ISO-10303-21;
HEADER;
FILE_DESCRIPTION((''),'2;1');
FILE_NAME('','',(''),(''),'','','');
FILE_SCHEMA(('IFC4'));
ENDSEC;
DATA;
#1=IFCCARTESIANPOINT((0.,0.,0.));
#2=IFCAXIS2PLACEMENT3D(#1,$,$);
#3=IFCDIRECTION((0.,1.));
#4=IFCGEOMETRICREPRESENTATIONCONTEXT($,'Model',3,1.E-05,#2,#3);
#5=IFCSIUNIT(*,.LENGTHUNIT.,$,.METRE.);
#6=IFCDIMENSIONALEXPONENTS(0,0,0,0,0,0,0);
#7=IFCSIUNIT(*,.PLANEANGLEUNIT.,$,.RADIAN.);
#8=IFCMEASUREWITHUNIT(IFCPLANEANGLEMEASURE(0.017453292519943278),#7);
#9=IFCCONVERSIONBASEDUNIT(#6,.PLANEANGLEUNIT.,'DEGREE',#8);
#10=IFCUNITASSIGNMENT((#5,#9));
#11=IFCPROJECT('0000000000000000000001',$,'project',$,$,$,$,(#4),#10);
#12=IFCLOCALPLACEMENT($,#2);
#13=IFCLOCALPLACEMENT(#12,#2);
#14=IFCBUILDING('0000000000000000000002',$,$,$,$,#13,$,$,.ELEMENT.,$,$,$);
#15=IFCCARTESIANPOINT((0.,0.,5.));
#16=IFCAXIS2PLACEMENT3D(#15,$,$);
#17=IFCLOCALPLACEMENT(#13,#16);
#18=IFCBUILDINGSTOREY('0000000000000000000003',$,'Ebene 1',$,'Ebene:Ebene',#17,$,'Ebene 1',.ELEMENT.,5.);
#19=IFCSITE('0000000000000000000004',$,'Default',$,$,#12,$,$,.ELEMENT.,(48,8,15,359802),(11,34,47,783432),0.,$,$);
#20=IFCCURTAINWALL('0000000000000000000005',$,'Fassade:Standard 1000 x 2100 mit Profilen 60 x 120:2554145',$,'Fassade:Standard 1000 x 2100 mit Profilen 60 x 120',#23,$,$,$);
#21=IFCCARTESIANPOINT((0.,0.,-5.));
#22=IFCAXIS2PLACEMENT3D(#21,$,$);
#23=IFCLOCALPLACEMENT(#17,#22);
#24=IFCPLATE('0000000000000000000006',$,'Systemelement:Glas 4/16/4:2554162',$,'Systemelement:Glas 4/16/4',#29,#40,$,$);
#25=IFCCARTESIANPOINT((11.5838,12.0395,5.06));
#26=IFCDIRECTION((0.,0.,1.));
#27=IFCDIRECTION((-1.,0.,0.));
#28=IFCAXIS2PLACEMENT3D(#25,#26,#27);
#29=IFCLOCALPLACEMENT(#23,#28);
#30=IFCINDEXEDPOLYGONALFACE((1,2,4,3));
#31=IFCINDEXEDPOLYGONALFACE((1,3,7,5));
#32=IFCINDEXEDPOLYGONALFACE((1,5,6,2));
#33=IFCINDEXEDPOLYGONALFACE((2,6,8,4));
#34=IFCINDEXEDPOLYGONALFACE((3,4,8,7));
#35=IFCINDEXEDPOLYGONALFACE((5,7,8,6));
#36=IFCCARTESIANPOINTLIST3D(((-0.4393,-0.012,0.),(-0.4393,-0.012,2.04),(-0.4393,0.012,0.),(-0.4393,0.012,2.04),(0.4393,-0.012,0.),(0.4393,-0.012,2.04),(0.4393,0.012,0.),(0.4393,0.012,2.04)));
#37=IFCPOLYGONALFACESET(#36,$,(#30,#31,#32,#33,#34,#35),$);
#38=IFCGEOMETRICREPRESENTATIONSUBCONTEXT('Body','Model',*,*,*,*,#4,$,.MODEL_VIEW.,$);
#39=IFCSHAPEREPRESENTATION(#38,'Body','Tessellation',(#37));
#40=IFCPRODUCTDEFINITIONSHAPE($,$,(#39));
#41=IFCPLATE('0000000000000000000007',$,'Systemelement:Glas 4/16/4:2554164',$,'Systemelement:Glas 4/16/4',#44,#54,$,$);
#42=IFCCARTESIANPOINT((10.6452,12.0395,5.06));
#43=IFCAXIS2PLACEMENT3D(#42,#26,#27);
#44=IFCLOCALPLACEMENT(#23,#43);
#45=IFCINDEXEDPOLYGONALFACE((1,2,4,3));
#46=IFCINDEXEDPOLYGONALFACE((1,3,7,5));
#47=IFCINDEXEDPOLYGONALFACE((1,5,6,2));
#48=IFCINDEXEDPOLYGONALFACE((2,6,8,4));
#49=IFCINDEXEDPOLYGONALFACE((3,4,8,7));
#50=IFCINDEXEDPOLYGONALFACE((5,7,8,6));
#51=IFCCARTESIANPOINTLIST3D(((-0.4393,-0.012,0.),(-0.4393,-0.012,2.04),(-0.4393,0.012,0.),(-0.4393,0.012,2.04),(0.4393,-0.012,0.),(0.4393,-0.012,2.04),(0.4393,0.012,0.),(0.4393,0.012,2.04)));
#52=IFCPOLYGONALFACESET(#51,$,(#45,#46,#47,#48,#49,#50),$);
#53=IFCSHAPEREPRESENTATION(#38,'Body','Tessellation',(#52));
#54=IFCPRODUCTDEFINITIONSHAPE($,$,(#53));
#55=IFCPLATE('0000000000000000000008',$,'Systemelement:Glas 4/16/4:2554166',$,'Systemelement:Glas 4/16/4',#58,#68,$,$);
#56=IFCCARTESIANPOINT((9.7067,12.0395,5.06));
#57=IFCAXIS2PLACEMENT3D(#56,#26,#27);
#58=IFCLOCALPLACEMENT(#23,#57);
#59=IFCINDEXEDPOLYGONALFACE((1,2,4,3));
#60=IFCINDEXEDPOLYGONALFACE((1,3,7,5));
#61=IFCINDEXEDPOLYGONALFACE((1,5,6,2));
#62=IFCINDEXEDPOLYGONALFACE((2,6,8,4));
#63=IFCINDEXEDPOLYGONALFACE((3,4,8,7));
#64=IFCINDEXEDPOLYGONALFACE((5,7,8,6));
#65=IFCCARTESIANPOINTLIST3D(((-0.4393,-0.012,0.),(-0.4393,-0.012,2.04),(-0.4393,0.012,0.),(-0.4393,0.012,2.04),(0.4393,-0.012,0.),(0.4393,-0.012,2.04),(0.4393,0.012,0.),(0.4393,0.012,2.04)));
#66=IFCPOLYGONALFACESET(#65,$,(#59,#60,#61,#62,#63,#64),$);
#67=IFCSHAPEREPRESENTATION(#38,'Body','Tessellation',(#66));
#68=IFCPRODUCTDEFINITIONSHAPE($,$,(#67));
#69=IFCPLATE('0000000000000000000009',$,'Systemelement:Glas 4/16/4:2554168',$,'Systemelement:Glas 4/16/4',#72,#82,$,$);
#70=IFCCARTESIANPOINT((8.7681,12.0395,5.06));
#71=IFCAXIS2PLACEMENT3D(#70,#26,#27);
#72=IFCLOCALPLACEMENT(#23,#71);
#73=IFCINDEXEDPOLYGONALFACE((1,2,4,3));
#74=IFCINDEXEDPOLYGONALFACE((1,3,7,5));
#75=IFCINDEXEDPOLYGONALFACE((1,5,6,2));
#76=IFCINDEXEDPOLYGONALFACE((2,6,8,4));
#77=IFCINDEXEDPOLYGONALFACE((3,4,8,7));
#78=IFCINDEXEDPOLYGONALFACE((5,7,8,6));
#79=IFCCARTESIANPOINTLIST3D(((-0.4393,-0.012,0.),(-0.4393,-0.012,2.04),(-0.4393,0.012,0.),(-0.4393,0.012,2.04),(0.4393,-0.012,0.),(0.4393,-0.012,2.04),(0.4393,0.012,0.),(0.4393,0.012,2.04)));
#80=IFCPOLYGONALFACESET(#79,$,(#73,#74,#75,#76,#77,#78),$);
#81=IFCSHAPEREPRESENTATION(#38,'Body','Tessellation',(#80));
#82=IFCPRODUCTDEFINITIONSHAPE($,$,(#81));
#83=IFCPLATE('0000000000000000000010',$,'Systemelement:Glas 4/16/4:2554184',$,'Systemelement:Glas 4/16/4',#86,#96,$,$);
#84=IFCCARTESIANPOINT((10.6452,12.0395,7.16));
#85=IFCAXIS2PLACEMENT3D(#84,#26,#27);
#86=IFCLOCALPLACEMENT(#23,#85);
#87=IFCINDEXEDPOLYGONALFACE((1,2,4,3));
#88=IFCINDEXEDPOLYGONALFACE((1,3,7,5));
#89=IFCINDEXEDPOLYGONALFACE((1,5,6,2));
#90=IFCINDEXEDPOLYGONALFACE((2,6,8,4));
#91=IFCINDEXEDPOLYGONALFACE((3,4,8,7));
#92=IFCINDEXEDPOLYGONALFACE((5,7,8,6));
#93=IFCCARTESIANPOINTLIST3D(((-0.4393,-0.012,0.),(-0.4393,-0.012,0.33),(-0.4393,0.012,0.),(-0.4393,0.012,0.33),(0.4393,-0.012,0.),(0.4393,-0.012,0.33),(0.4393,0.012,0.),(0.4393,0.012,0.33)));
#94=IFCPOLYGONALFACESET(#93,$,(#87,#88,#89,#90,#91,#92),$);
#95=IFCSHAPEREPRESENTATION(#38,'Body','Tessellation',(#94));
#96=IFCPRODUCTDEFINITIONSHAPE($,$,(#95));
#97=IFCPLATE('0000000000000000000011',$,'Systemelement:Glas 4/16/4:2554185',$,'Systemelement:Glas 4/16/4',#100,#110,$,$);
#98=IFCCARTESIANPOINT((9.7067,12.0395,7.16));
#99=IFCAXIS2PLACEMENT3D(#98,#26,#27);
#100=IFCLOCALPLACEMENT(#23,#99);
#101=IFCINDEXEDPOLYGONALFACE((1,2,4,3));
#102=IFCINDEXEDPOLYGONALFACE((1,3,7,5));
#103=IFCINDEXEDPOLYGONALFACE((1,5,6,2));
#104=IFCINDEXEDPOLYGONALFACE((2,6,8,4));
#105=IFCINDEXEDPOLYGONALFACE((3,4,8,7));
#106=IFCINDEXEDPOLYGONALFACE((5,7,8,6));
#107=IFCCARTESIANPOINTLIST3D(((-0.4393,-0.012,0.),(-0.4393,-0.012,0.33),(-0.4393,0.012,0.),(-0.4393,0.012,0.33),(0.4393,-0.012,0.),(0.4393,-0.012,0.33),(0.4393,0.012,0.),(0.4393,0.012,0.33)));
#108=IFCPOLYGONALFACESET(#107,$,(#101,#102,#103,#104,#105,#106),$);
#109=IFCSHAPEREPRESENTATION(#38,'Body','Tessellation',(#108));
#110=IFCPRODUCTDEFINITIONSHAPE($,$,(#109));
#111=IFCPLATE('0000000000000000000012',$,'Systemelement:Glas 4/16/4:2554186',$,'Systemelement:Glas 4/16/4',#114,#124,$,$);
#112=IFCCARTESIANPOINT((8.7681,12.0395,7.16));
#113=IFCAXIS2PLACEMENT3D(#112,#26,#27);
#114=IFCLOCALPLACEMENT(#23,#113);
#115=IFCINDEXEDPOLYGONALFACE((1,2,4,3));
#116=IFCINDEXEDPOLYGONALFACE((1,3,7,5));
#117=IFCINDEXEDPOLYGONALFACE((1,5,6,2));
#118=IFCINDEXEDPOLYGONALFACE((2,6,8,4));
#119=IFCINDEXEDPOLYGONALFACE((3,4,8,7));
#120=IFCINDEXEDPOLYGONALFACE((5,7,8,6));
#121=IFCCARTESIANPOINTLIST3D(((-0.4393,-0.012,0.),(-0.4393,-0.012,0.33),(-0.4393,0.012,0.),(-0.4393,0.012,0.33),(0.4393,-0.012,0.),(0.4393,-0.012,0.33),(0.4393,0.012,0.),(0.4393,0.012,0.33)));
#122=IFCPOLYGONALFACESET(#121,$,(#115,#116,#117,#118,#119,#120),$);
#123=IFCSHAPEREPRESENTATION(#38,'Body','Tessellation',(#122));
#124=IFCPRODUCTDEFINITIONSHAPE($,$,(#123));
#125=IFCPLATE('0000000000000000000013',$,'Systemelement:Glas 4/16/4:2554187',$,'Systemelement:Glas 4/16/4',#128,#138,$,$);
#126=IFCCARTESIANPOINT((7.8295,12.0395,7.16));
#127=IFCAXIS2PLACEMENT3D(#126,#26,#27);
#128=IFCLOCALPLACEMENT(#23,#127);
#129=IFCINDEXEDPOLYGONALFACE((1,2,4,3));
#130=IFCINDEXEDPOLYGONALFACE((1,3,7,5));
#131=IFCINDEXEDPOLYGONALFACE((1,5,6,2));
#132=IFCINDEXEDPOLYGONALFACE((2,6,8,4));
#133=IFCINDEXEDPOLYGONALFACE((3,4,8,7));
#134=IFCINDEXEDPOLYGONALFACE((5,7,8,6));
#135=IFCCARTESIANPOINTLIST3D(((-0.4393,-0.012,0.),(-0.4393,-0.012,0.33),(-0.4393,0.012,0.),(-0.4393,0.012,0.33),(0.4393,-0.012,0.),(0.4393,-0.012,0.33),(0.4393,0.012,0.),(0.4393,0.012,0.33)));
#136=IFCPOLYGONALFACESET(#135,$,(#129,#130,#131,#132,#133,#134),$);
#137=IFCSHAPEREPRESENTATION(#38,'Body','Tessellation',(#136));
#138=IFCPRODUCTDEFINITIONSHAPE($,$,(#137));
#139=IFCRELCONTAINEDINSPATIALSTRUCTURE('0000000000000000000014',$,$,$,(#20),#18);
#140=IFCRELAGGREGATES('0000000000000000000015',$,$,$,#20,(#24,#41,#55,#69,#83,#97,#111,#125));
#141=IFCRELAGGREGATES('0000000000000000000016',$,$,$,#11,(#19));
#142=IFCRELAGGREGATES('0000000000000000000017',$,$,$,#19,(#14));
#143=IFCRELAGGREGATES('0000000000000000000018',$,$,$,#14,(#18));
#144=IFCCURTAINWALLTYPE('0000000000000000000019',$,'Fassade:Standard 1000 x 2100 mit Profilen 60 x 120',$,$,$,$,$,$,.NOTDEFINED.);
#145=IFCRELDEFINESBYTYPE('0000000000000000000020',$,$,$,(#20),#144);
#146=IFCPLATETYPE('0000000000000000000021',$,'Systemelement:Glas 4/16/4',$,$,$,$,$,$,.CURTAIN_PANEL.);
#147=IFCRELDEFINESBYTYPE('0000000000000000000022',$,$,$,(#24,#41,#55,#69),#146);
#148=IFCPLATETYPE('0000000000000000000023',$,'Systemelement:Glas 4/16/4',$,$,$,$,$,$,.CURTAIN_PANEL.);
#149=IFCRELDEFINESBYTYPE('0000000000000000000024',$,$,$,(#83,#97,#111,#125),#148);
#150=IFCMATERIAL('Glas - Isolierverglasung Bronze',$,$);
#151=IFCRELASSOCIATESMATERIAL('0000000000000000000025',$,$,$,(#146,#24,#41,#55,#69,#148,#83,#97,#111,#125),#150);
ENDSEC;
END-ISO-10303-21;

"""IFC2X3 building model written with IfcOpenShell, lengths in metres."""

from ifc_helpers import new_model, entity, si_unit, converted_unit, direction, frame, origin, origin_2d_with_axis, place, context, subcontext, project, spatial, rectangle, extrude, source, transform, mapped, material, type_object, type_shapes, element, aggregate, save


model = new_model("IFC2X3")

# Units and contexts
model_context = context("Model", 3, precision=1e-05, world=origin(), true_north=direction((0.0, 1.0)))
body_context = subcontext(model_context, "Body", "Model", "MODEL_VIEW")
ifc_project = project(units=[si_unit("LENGTHUNIT", "METRE"), converted_unit("PLANEANGLEUNIT", "DEGREE", entity("IfcPlaneAngleMeasure", 0.017453292519943278), si_unit("PLANEANGLEUNIT", "RADIAN"), dimensions=[0, 0, 0, 0, 0, 0, 0])], contexts=[model_context])

# Site, building, storey
site_placement = place(None, origin())
site = spatial("IfcSite", under=ifc_project, at=site_placement, Name="Default", CompositionType="ELEMENT", RefLatitude=(48, 8, 15, 359802), RefLongitude=(11, 34, 47, 783432), RefElevation=0.0)
building_placement = place(site_placement, origin())
building = spatial("IfcBuilding", under=site, at=building_placement, CompositionType="ELEMENT")
storey_placement = place(building_placement, frame((0.0, 0.0, 5.0)))
storey = spatial("IfcBuildingStorey", under=building, at=storey_placement, Name="Ebene 1", ObjectType="Ebene:Ebene", LongName="Ebene 1", CompositionType="ELEMENT", Elevation=5.0)

# Curtain wall
curtain_wall_type = type_object("IfcCurtainWallType", Name="Fassade:Standard 1000 x 2100 mit Profilen 60 x 120", PredefinedType="NOTDEFINED")
curtain_wall_placement = place(storey_placement, frame((0.0, 0.0, -5.0)))
curtain_wall = element("IfcCurtainWall", 1, at=curtain_wall_placement, inside=storey, type_object=curtain_wall_type, Name="Fassade:Standard 1000 x 2100 mit Profilen 60 x 120:2554145", ObjectType="Fassade:Standard 1000 x 2100 mit Profilen 60 x 120")

# Plates
ifc_material_1 = material(Name="Glas - Isolierverglasung Bronze")
plate_type_1 = type_object("IfcPlateType", Name="Systemelement:Glas 4/16/4", PredefinedType="CURTAIN_PANEL", material=ifc_material_1)
shared_shape_1 = source(origin(), body_context, "Body", "SweptSolid", [
    extrude(rectangle(XDim=0.024, YDim=0.8786, at=origin_2d_with_axis()), frame((0.0, 0.0, 0.0), z_axis=(0.0, 0.0, 1.0), x_axis=(0.0, 1.0, 0.0)), (0.0, 0.0, 1.0), 2.04),
])
type_shapes(plate_type_1, [shared_shape_1])
plate_1_placement = place(curtain_wall_placement, frame((11.5838, 12.0395, 5.06), z_axis=(0.0, 0.0, 1.0), x_axis=(-1.0, 0.0, 0.0)))
plate_1 = element("IfcPlate", 2, at=plate_1_placement, type_object=plate_type_1, material=ifc_material_1, Name="Systemelement:Glas 4/16/4:2554162", ObjectType="Systemelement:Glas 4/16/4", context=body_context, shape_type="MappedRepresentation", body=[
    mapped(shared_shape_1, transform((0.0, 0.0, 0.0), scale=1.0)),
])
plate_2_placement = place(curtain_wall_placement, frame((10.6452, 12.0395, 5.06), z_axis=(0.0, 0.0, 1.0), x_axis=(-1.0, 0.0, 0.0)))
plate_2 = element("IfcPlate", 3, at=plate_2_placement, type_object=plate_type_1, material=ifc_material_1, Name="Systemelement:Glas 4/16/4:2554164", ObjectType="Systemelement:Glas 4/16/4", context=body_context, shape_type="MappedRepresentation", body=[
    mapped(shared_shape_1, transform((0.0, 0.0, 0.0), scale=1.0)),
])
plate_3_placement = place(curtain_wall_placement, frame((9.7067, 12.0395, 5.06), z_axis=(0.0, 0.0, 1.0), x_axis=(-1.0, 0.0, 0.0)))
plate_3 = element("IfcPlate", 4, at=plate_3_placement, type_object=plate_type_1, material=ifc_material_1, Name="Systemelement:Glas 4/16/4:2554166", ObjectType="Systemelement:Glas 4/16/4", context=body_context, shape_type="MappedRepresentation", body=[
    mapped(shared_shape_1, transform((0.0, 0.0, 0.0), scale=1.0)),
])
plate_4_placement = place(curtain_wall_placement, frame((8.7681, 12.0395, 5.06), z_axis=(0.0, 0.0, 1.0), x_axis=(-1.0, 0.0, 0.0)))
plate_4 = element("IfcPlate", 5, at=plate_4_placement, type_object=plate_type_1, material=ifc_material_1, Name="Systemelement:Glas 4/16/4:2554168", ObjectType="Systemelement:Glas 4/16/4", context=body_context, shape_type="MappedRepresentation", body=[
    mapped(shared_shape_1, transform((0.0, 0.0, 0.0), scale=1.0)),
])
plate_type_2 = type_object("IfcPlateType", Name="Systemelement:Glas 4/16/4", PredefinedType="CURTAIN_PANEL", material=ifc_material_1)
shared_shape_2 = source(origin(), body_context, "Body", "SweptSolid", [
    extrude(rectangle(XDim=0.024, YDim=0.8786, at=origin_2d_with_axis()), frame((0.0, 0.0, 0.0), z_axis=(0.0, 0.0, 1.0), x_axis=(0.0, 1.0, 0.0)), (0.0, 0.0, 1.0), 0.33),
])
type_shapes(plate_type_2, [shared_shape_2])
plate_5_placement = place(curtain_wall_placement, frame((10.6452, 12.0395, 7.16), z_axis=(0.0, 0.0, 1.0), x_axis=(-1.0, 0.0, 0.0)))
plate_5 = element("IfcPlate", 6, at=plate_5_placement, type_object=plate_type_2, material=ifc_material_1, Name="Systemelement:Glas 4/16/4:2554184", ObjectType="Systemelement:Glas 4/16/4", context=body_context, shape_type="MappedRepresentation", body=[
    mapped(shared_shape_2, transform((0.0, 0.0, 0.0), scale=1.0)),
])
plate_6_placement = place(curtain_wall_placement, frame((9.7067, 12.0395, 7.16), z_axis=(0.0, 0.0, 1.0), x_axis=(-1.0, 0.0, 0.0)))
plate_6 = element("IfcPlate", 7, at=plate_6_placement, type_object=plate_type_2, material=ifc_material_1, Name="Systemelement:Glas 4/16/4:2554185", ObjectType="Systemelement:Glas 4/16/4", context=body_context, shape_type="MappedRepresentation", body=[
    mapped(shared_shape_2, transform((0.0, 0.0, 0.0), scale=1.0)),
])
plate_7_placement = place(curtain_wall_placement, frame((8.7681, 12.0395, 7.16), z_axis=(0.0, 0.0, 1.0), x_axis=(-1.0, 0.0, 0.0)))
plate_7 = element("IfcPlate", 8, at=plate_7_placement, type_object=plate_type_2, material=ifc_material_1, Name="Systemelement:Glas 4/16/4:2554186", ObjectType="Systemelement:Glas 4/16/4", context=body_context, shape_type="MappedRepresentation", body=[
    mapped(shared_shape_2, transform((0.0, 0.0, 0.0), scale=1.0)),
])
plate_8_placement = place(curtain_wall_placement, frame((7.8295, 12.0395, 7.16), z_axis=(0.0, 0.0, 1.0), x_axis=(-1.0, 0.0, 0.0)))
plate_8 = element("IfcPlate", 9, at=plate_8_placement, type_object=plate_type_2, material=ifc_material_1, Name="Systemelement:Glas 4/16/4:2554187", ObjectType="Systemelement:Glas 4/16/4", context=body_context, shape_type="MappedRepresentation", body=[
    mapped(shared_shape_2, transform((0.0, 0.0, 0.0), scale=1.0)),
])
aggregate(curtain_wall, [plate_1, plate_2, plate_3, plate_4, plate_5, plate_6, plate_7, plate_8])

save(model, "model.ifc")
